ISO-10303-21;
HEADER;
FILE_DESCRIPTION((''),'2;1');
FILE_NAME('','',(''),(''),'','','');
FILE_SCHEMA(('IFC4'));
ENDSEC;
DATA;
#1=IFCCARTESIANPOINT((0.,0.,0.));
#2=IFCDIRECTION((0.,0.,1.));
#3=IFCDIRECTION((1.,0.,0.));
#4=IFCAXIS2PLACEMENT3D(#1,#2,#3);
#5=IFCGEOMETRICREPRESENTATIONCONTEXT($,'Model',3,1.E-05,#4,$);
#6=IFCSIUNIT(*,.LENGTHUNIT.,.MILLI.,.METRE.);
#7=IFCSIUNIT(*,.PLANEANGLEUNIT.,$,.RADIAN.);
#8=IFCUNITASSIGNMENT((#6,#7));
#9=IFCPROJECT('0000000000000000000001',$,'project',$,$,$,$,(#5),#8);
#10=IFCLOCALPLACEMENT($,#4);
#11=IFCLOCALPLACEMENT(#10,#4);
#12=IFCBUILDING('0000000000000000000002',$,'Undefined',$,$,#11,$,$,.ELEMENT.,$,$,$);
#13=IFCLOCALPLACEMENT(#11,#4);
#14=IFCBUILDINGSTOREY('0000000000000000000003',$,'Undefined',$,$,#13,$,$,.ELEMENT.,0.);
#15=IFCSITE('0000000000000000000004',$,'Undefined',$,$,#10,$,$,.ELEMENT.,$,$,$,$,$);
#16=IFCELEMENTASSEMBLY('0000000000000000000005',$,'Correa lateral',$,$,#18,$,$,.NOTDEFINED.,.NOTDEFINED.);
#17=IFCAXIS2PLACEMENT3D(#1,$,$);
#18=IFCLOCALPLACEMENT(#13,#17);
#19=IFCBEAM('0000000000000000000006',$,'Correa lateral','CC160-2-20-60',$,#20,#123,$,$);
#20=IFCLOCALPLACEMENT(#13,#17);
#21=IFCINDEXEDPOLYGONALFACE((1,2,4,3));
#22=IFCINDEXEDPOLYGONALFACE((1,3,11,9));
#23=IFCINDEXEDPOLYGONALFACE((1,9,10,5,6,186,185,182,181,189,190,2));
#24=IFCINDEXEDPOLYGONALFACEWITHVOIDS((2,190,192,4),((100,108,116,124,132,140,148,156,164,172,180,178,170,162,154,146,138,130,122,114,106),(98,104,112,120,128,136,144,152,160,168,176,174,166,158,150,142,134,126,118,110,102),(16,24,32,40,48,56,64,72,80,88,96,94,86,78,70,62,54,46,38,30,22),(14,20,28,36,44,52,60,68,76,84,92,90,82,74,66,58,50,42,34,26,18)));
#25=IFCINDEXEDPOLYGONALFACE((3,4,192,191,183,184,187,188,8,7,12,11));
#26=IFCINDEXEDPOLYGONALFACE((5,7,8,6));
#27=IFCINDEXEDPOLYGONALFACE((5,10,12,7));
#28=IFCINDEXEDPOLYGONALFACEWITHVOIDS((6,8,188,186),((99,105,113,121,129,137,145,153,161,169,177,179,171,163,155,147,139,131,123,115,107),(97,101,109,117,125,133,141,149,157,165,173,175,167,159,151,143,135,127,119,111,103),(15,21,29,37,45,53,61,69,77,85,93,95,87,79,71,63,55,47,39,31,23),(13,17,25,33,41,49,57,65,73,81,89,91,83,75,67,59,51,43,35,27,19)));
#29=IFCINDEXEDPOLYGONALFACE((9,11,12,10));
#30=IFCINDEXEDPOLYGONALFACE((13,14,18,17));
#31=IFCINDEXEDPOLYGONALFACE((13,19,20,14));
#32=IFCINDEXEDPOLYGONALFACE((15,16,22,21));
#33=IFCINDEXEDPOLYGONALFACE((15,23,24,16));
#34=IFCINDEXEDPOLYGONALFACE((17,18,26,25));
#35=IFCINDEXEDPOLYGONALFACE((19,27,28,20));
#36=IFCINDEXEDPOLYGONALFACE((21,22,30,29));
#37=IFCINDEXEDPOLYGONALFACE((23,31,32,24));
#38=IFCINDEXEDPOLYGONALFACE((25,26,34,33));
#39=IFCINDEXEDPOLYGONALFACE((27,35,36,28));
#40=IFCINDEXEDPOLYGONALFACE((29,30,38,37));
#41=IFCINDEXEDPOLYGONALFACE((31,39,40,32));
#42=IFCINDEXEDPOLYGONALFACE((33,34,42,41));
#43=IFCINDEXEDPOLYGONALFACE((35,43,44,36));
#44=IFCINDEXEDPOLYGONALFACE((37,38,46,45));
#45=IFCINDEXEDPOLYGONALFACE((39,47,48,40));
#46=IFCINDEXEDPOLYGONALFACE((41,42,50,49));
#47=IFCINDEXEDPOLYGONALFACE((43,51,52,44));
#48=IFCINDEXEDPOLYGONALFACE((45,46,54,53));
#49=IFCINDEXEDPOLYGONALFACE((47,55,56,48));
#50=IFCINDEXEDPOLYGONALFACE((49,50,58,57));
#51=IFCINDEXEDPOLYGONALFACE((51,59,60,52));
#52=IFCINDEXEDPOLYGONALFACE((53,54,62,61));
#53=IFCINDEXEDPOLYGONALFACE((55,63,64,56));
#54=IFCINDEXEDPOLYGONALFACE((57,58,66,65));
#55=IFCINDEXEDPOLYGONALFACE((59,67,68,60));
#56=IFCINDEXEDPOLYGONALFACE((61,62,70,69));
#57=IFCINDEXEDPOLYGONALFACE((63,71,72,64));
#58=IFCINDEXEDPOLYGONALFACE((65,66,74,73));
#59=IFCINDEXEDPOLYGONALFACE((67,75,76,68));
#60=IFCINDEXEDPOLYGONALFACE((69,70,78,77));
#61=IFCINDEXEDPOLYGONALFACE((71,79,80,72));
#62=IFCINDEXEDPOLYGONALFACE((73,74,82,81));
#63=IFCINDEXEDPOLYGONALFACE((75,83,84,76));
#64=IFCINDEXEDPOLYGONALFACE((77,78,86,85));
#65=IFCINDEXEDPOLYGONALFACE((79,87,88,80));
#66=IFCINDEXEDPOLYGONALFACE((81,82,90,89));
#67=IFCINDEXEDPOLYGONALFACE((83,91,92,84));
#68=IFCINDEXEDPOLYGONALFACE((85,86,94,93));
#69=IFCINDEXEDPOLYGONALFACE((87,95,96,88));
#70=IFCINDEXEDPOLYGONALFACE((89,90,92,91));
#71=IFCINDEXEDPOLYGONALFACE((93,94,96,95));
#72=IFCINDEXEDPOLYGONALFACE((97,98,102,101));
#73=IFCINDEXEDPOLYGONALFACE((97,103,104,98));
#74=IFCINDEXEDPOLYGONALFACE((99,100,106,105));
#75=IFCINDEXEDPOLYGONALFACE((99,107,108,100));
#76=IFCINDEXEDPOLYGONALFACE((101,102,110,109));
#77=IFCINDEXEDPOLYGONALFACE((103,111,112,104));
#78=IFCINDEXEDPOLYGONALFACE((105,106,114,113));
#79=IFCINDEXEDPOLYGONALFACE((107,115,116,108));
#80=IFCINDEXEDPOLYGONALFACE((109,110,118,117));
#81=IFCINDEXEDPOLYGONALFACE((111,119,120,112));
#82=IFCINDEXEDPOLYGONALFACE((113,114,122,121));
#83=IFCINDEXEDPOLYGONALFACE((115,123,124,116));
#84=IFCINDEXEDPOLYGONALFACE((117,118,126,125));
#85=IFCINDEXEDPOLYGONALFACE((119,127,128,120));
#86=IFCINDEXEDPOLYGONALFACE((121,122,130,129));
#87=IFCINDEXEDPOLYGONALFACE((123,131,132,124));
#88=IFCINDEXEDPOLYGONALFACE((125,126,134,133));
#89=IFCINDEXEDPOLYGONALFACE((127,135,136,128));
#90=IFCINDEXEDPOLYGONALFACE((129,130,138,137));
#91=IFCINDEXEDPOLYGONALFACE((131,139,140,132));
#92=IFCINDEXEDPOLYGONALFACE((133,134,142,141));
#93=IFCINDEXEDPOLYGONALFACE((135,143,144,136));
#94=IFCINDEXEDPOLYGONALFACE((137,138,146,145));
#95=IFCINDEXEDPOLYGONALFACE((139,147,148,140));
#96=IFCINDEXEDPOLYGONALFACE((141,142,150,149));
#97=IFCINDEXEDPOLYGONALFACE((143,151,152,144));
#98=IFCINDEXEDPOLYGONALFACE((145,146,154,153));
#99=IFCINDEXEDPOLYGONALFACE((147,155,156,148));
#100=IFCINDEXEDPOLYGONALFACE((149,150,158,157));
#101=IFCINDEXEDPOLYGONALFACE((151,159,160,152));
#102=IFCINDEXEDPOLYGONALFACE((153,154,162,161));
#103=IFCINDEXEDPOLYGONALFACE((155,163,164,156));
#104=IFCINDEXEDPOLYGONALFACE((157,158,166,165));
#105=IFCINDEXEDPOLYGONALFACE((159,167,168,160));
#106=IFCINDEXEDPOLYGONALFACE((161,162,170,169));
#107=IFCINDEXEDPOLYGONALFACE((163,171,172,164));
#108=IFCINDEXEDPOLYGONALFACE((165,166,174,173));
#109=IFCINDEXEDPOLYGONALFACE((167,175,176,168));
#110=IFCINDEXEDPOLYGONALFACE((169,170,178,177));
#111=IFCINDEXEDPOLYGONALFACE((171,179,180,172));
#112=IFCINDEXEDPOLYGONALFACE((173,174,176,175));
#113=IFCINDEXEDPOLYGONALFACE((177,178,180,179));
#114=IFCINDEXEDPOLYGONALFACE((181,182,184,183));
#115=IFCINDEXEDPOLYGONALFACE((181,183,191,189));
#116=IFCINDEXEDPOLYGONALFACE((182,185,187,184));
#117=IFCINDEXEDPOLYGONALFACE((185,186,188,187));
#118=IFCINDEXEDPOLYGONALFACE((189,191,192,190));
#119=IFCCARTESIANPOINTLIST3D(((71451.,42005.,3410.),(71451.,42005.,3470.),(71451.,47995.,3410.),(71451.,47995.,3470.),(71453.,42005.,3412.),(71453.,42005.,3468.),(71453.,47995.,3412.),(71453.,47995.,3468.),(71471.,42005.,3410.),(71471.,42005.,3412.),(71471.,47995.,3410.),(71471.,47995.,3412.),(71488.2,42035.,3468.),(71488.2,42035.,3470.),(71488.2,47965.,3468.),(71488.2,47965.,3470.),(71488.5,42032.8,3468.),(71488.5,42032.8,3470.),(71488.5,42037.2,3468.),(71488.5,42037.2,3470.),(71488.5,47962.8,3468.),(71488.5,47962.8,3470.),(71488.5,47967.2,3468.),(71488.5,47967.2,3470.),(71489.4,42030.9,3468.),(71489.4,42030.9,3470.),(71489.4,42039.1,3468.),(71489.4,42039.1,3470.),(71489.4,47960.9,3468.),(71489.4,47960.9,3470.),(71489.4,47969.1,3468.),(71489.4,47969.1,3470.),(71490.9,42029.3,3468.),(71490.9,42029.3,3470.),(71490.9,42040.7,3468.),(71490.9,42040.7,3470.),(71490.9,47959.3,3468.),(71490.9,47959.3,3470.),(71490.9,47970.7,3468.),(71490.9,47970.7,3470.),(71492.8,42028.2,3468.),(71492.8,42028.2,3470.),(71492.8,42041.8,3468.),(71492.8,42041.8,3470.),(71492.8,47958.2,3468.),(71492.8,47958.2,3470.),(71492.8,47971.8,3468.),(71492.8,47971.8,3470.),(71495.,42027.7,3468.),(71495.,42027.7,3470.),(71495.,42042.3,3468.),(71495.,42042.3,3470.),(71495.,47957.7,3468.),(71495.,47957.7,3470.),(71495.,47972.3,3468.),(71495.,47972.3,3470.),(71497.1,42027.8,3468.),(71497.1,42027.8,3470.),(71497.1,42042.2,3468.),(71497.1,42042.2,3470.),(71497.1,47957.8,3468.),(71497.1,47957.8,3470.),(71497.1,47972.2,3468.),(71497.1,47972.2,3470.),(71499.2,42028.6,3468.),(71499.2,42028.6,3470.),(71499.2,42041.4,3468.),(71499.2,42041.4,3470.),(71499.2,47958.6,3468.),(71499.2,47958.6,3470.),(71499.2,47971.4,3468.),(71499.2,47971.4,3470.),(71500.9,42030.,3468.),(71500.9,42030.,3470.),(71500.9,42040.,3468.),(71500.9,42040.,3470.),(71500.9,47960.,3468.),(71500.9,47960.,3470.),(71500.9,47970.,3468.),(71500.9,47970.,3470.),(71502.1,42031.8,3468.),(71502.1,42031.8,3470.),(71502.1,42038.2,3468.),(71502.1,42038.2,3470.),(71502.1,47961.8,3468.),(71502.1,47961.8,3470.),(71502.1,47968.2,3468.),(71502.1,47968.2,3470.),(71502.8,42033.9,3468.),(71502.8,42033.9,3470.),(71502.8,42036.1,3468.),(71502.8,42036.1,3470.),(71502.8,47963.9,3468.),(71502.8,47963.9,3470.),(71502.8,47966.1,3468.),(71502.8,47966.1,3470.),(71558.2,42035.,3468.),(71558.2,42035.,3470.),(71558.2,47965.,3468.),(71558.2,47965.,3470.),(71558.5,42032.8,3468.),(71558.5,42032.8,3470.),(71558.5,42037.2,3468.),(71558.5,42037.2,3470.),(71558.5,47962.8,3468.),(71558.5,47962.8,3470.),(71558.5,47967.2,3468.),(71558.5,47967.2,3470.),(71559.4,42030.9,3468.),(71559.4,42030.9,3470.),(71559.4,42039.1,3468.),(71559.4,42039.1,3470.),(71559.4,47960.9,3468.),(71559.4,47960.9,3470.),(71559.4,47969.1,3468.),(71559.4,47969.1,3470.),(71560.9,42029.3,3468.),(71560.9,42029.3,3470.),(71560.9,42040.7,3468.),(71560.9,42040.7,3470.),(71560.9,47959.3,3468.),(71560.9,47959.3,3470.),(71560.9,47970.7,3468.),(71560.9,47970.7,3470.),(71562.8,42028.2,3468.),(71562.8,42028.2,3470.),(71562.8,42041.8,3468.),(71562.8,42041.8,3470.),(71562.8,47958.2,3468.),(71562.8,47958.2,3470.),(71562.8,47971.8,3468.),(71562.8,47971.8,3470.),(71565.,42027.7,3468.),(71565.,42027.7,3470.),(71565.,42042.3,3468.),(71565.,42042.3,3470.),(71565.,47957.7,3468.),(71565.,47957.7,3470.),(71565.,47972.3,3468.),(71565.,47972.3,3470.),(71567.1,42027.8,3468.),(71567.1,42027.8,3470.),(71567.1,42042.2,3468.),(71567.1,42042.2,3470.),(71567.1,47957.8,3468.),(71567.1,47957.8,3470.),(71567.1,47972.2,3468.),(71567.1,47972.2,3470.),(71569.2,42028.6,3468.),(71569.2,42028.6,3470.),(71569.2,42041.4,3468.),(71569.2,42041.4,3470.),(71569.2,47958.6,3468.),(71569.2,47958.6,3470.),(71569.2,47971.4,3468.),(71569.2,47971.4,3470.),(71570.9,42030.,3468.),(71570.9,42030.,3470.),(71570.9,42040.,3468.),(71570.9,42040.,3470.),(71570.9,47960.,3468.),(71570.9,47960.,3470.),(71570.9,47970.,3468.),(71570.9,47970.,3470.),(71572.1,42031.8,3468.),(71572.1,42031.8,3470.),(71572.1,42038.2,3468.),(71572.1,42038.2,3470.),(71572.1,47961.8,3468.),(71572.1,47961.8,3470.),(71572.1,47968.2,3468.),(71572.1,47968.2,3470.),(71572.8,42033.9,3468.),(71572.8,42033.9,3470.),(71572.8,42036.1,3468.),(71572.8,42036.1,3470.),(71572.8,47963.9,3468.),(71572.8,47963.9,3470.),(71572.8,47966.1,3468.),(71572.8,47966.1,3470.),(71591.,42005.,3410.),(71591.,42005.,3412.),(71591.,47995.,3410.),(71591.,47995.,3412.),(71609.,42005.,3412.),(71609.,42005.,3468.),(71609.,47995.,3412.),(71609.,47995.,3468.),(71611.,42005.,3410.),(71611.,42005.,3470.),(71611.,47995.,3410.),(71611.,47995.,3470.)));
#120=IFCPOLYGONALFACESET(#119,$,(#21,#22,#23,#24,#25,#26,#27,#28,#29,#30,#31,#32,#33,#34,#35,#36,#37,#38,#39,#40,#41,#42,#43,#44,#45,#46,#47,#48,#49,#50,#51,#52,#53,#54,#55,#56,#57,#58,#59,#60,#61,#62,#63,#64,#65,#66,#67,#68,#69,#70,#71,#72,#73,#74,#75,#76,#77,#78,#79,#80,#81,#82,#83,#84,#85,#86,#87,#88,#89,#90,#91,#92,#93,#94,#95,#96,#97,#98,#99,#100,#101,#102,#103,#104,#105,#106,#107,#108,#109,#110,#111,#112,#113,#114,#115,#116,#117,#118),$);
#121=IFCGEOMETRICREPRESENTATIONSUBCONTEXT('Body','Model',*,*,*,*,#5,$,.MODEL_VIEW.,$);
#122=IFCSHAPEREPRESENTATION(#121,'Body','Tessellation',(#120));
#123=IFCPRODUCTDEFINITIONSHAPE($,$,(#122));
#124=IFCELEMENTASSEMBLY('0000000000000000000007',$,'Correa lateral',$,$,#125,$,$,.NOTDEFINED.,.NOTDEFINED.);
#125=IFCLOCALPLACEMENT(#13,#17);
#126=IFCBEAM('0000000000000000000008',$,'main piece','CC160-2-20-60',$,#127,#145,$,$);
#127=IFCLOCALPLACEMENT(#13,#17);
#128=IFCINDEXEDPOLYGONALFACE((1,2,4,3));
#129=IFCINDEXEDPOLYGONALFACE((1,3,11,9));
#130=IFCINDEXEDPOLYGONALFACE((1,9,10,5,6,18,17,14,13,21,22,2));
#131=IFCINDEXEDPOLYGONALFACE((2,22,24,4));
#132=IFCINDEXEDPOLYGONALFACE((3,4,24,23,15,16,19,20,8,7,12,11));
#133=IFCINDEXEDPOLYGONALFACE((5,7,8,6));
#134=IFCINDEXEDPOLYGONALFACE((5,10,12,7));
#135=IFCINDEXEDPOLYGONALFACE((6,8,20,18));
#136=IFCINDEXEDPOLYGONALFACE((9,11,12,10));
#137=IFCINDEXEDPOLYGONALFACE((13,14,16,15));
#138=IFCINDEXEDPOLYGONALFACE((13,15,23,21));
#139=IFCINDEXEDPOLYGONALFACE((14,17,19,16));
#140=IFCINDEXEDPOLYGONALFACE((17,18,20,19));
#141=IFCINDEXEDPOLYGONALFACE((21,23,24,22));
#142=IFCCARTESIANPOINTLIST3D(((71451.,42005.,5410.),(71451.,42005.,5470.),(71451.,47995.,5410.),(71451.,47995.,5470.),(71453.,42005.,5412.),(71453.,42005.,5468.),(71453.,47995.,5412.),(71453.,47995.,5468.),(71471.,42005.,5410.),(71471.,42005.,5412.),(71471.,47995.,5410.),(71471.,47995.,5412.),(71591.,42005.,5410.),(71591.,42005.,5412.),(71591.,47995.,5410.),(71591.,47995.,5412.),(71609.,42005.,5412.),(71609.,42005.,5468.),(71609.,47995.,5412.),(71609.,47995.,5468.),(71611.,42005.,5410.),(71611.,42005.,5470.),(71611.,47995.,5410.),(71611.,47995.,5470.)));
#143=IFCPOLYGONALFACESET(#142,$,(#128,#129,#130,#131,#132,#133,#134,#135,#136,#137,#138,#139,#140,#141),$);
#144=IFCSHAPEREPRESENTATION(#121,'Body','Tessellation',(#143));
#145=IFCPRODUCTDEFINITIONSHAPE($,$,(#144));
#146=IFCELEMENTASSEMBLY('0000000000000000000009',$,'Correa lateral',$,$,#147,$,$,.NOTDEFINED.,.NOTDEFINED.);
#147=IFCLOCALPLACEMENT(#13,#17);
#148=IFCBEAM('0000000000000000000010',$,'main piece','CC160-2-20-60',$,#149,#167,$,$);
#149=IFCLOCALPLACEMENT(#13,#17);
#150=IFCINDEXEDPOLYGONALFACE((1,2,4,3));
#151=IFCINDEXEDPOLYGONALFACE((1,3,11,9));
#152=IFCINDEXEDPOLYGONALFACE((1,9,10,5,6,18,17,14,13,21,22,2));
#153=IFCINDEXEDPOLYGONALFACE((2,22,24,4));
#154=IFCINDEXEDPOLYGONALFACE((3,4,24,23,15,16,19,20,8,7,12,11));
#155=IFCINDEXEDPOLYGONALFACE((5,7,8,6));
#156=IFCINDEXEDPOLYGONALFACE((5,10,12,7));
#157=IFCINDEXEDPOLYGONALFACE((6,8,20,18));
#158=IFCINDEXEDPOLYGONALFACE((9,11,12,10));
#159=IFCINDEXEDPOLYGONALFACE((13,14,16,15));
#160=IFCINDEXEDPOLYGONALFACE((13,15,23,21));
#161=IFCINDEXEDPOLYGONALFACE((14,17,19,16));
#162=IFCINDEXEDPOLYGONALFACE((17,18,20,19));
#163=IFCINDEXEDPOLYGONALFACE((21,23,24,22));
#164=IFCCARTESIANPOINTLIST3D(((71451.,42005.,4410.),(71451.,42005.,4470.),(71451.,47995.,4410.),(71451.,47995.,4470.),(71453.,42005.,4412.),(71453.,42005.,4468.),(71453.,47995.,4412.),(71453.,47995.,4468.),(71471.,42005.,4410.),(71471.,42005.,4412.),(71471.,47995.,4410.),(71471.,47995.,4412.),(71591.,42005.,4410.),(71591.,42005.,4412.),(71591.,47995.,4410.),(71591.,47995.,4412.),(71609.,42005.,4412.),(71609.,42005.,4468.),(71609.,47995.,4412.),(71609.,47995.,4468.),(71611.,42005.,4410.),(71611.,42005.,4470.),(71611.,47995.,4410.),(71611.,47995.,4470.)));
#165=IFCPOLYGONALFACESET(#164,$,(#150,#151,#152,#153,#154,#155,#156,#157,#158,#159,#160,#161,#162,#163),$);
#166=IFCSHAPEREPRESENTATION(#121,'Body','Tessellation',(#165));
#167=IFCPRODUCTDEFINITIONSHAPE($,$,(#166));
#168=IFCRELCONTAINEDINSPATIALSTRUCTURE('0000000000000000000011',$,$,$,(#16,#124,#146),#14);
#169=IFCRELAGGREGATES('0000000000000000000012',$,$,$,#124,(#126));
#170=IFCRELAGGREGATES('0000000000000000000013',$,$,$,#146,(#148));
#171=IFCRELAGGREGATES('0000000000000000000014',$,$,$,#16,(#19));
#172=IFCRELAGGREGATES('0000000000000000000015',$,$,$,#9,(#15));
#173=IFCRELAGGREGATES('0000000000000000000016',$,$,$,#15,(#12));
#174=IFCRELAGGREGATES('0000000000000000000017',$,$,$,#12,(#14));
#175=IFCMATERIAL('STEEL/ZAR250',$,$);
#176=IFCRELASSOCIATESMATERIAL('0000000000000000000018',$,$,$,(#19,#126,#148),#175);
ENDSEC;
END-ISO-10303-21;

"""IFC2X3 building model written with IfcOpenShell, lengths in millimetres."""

from ifc_helpers import new_model, si_unit, frame, origin_with_axes, origin_2d_with_axis, place, context, subcontext, project, spatial, circle, c_section, extrude, source, transform, mapped, material, element, aggregate, save


model = new_model("IFC2X3")

# Units and contexts
model_context = context("Model", 3, precision=1e-05, world=origin_with_axes())
body_context = subcontext(model_context, "Body", "Model", "MODEL_VIEW")
ifc_project = project(units=[si_unit("LENGTHUNIT", "METRE", prefix="MILLI"), si_unit("PLANEANGLEUNIT", "RADIAN")], contexts=[model_context])

# Site, building, storey
site_placement = place(None, origin_with_axes())
site = spatial("IfcSite", under=ifc_project, at=site_placement, Name="Undefined", CompositionType="ELEMENT")
building_placement = place(site_placement, origin_with_axes())
building = spatial("IfcBuilding", under=site, at=building_placement, Name="Undefined", CompositionType="ELEMENT")
storey_placement = place(building_placement, origin_with_axes())
storey = spatial("IfcBuildingStorey", under=building, at=storey_placement, Name="Undefined", CompositionType="ELEMENT", Elevation=0.0)

# Shared definitions
ifc_material_1 = material(Name="STEEL/ZAR250")

# Element assembly, beam, openings
assembly_1_placement = place(storey_placement, origin_with_axes())
assembly_1 = element("IfcElementAssembly", 1, at=assembly_1_placement, inside=storey, Name="Correa lateral", AssemblyPlace="NOTDEFINED", PredefinedType="NOTDEFINED")
beam_1_placement = place(assembly_1_placement, frame((71531.0, 47995.0, 3440.0), z_axis=(-1.0, 0.0, 0.0), x_axis=(0.0, -1.0, 0.0)))
beam_1 = element("IfcBeam", 2, at=beam_1_placement, material=ifc_material_1, Name="Correa lateral", Description="CC160-2-20-60", context=body_context, shape_type="SweptSolid", body=[
    extrude(c_section(Depth=160.0, Width=60.0, WallThickness=2.0, Girth=20.0, at=origin_2d_with_axis()), frame((5990.0, 0.0, 0.0), z_axis=(-1.0, 0.0, 0.0), x_axis=(0.0, -1.0, 0.0)), (0.0, 0.0, 1.0), 5990.0),
])
shared_shape_1 = source(origin_with_axes(), body_context, "Body", "SweptSolid", [
    extrude(circle(Radius=7.3, at=origin_2d_with_axis()), frame((0.0, -0.1, 0.0), z_axis=(0.0, 1.0, 0.0), x_axis=(1.0, 0.0, 0.0)), (0.0, 0.0, 1.0), 2.2),
])
opening_1_placement = place(assembly_1_placement, frame((71565.5, 42035.0, 3470.0), z_axis=(0.0, -1.0, 0.0), x_axis=(-1.0, 0.0, 0.0)))
element("IfcOpeningElement", 3, at=opening_1_placement, cuts=beam_1, ObjectType="Opening", context=body_context, shape_type="MappedRepresentation", body=[
    mapped(shared_shape_1, transform((0.0, 0.0, 0.0))),
    mapped(shared_shape_1, transform((70.0, 0.0, 0.0))),
])
opening_2_placement = place(assembly_1_placement, frame((71565.5, 47965.0, 3470.0), z_axis=(0.0, -1.0, 0.0), x_axis=(-1.0, 0.0, 0.0)))
element("IfcOpeningElement", 4, at=opening_2_placement, cuts=beam_1, ObjectType="Opening", context=body_context, shape_type="MappedRepresentation", body=[
    mapped(shared_shape_1, transform((0.0, 0.0, 0.0))),
    mapped(shared_shape_1, transform((70.0, 0.0, 0.0))),
])

# Element assemblies, beams
assembly_2_placement = place(storey_placement, origin_with_axes())
assembly_2 = element("IfcElementAssembly", 5, at=assembly_2_placement, inside=storey, Name="Correa lateral", AssemblyPlace="NOTDEFINED", PredefinedType="NOTDEFINED")
beam_2_placement = place(assembly_2_placement, frame((71531.0, 47995.0, 5440.0), z_axis=(-1.0, 0.0, 0.0), x_axis=(0.0, -1.0, 0.0)))
beam_2 = element("IfcBeam", 6, at=beam_2_placement, material=ifc_material_1, Name="main piece", Description="CC160-2-20-60", context=body_context, shape_type="SweptSolid", body=[
    extrude(c_section(Depth=160.0, Width=60.0, WallThickness=2.0, Girth=20.0, at=origin_2d_with_axis()), frame((5990.0, 0.0, 0.0), z_axis=(-1.0, 0.0, 0.0), x_axis=(0.0, -1.0, 0.0)), (0.0, 0.0, 1.0), 5990.0),
])
aggregate(assembly_2, [beam_2])
assembly_3_placement = place(storey_placement, origin_with_axes())
assembly_3 = element("IfcElementAssembly", 7, at=assembly_3_placement, inside=storey, Name="Correa lateral", AssemblyPlace="NOTDEFINED", PredefinedType="NOTDEFINED")
beam_3_placement = place(assembly_3_placement, frame((71531.0, 47995.0, 4440.0), z_axis=(-1.0, 0.0, 0.0), x_axis=(0.0, -1.0, 0.0)))
beam_3 = element("IfcBeam", 8, at=beam_3_placement, material=ifc_material_1, Name="main piece", Description="CC160-2-20-60", context=body_context, shape_type="SweptSolid", body=[
    extrude(c_section(Depth=160.0, Width=60.0, WallThickness=2.0, Girth=20.0, at=origin_2d_with_axis()), frame((5990.0, 0.0, 0.0), z_axis=(-1.0, 0.0, 0.0), x_axis=(0.0, -1.0, 0.0)), (0.0, 0.0, 1.0), 5990.0),
])
aggregate(assembly_3, [beam_3])

aggregate(assembly_1, [beam_1])

save(model, "model.ifc")
